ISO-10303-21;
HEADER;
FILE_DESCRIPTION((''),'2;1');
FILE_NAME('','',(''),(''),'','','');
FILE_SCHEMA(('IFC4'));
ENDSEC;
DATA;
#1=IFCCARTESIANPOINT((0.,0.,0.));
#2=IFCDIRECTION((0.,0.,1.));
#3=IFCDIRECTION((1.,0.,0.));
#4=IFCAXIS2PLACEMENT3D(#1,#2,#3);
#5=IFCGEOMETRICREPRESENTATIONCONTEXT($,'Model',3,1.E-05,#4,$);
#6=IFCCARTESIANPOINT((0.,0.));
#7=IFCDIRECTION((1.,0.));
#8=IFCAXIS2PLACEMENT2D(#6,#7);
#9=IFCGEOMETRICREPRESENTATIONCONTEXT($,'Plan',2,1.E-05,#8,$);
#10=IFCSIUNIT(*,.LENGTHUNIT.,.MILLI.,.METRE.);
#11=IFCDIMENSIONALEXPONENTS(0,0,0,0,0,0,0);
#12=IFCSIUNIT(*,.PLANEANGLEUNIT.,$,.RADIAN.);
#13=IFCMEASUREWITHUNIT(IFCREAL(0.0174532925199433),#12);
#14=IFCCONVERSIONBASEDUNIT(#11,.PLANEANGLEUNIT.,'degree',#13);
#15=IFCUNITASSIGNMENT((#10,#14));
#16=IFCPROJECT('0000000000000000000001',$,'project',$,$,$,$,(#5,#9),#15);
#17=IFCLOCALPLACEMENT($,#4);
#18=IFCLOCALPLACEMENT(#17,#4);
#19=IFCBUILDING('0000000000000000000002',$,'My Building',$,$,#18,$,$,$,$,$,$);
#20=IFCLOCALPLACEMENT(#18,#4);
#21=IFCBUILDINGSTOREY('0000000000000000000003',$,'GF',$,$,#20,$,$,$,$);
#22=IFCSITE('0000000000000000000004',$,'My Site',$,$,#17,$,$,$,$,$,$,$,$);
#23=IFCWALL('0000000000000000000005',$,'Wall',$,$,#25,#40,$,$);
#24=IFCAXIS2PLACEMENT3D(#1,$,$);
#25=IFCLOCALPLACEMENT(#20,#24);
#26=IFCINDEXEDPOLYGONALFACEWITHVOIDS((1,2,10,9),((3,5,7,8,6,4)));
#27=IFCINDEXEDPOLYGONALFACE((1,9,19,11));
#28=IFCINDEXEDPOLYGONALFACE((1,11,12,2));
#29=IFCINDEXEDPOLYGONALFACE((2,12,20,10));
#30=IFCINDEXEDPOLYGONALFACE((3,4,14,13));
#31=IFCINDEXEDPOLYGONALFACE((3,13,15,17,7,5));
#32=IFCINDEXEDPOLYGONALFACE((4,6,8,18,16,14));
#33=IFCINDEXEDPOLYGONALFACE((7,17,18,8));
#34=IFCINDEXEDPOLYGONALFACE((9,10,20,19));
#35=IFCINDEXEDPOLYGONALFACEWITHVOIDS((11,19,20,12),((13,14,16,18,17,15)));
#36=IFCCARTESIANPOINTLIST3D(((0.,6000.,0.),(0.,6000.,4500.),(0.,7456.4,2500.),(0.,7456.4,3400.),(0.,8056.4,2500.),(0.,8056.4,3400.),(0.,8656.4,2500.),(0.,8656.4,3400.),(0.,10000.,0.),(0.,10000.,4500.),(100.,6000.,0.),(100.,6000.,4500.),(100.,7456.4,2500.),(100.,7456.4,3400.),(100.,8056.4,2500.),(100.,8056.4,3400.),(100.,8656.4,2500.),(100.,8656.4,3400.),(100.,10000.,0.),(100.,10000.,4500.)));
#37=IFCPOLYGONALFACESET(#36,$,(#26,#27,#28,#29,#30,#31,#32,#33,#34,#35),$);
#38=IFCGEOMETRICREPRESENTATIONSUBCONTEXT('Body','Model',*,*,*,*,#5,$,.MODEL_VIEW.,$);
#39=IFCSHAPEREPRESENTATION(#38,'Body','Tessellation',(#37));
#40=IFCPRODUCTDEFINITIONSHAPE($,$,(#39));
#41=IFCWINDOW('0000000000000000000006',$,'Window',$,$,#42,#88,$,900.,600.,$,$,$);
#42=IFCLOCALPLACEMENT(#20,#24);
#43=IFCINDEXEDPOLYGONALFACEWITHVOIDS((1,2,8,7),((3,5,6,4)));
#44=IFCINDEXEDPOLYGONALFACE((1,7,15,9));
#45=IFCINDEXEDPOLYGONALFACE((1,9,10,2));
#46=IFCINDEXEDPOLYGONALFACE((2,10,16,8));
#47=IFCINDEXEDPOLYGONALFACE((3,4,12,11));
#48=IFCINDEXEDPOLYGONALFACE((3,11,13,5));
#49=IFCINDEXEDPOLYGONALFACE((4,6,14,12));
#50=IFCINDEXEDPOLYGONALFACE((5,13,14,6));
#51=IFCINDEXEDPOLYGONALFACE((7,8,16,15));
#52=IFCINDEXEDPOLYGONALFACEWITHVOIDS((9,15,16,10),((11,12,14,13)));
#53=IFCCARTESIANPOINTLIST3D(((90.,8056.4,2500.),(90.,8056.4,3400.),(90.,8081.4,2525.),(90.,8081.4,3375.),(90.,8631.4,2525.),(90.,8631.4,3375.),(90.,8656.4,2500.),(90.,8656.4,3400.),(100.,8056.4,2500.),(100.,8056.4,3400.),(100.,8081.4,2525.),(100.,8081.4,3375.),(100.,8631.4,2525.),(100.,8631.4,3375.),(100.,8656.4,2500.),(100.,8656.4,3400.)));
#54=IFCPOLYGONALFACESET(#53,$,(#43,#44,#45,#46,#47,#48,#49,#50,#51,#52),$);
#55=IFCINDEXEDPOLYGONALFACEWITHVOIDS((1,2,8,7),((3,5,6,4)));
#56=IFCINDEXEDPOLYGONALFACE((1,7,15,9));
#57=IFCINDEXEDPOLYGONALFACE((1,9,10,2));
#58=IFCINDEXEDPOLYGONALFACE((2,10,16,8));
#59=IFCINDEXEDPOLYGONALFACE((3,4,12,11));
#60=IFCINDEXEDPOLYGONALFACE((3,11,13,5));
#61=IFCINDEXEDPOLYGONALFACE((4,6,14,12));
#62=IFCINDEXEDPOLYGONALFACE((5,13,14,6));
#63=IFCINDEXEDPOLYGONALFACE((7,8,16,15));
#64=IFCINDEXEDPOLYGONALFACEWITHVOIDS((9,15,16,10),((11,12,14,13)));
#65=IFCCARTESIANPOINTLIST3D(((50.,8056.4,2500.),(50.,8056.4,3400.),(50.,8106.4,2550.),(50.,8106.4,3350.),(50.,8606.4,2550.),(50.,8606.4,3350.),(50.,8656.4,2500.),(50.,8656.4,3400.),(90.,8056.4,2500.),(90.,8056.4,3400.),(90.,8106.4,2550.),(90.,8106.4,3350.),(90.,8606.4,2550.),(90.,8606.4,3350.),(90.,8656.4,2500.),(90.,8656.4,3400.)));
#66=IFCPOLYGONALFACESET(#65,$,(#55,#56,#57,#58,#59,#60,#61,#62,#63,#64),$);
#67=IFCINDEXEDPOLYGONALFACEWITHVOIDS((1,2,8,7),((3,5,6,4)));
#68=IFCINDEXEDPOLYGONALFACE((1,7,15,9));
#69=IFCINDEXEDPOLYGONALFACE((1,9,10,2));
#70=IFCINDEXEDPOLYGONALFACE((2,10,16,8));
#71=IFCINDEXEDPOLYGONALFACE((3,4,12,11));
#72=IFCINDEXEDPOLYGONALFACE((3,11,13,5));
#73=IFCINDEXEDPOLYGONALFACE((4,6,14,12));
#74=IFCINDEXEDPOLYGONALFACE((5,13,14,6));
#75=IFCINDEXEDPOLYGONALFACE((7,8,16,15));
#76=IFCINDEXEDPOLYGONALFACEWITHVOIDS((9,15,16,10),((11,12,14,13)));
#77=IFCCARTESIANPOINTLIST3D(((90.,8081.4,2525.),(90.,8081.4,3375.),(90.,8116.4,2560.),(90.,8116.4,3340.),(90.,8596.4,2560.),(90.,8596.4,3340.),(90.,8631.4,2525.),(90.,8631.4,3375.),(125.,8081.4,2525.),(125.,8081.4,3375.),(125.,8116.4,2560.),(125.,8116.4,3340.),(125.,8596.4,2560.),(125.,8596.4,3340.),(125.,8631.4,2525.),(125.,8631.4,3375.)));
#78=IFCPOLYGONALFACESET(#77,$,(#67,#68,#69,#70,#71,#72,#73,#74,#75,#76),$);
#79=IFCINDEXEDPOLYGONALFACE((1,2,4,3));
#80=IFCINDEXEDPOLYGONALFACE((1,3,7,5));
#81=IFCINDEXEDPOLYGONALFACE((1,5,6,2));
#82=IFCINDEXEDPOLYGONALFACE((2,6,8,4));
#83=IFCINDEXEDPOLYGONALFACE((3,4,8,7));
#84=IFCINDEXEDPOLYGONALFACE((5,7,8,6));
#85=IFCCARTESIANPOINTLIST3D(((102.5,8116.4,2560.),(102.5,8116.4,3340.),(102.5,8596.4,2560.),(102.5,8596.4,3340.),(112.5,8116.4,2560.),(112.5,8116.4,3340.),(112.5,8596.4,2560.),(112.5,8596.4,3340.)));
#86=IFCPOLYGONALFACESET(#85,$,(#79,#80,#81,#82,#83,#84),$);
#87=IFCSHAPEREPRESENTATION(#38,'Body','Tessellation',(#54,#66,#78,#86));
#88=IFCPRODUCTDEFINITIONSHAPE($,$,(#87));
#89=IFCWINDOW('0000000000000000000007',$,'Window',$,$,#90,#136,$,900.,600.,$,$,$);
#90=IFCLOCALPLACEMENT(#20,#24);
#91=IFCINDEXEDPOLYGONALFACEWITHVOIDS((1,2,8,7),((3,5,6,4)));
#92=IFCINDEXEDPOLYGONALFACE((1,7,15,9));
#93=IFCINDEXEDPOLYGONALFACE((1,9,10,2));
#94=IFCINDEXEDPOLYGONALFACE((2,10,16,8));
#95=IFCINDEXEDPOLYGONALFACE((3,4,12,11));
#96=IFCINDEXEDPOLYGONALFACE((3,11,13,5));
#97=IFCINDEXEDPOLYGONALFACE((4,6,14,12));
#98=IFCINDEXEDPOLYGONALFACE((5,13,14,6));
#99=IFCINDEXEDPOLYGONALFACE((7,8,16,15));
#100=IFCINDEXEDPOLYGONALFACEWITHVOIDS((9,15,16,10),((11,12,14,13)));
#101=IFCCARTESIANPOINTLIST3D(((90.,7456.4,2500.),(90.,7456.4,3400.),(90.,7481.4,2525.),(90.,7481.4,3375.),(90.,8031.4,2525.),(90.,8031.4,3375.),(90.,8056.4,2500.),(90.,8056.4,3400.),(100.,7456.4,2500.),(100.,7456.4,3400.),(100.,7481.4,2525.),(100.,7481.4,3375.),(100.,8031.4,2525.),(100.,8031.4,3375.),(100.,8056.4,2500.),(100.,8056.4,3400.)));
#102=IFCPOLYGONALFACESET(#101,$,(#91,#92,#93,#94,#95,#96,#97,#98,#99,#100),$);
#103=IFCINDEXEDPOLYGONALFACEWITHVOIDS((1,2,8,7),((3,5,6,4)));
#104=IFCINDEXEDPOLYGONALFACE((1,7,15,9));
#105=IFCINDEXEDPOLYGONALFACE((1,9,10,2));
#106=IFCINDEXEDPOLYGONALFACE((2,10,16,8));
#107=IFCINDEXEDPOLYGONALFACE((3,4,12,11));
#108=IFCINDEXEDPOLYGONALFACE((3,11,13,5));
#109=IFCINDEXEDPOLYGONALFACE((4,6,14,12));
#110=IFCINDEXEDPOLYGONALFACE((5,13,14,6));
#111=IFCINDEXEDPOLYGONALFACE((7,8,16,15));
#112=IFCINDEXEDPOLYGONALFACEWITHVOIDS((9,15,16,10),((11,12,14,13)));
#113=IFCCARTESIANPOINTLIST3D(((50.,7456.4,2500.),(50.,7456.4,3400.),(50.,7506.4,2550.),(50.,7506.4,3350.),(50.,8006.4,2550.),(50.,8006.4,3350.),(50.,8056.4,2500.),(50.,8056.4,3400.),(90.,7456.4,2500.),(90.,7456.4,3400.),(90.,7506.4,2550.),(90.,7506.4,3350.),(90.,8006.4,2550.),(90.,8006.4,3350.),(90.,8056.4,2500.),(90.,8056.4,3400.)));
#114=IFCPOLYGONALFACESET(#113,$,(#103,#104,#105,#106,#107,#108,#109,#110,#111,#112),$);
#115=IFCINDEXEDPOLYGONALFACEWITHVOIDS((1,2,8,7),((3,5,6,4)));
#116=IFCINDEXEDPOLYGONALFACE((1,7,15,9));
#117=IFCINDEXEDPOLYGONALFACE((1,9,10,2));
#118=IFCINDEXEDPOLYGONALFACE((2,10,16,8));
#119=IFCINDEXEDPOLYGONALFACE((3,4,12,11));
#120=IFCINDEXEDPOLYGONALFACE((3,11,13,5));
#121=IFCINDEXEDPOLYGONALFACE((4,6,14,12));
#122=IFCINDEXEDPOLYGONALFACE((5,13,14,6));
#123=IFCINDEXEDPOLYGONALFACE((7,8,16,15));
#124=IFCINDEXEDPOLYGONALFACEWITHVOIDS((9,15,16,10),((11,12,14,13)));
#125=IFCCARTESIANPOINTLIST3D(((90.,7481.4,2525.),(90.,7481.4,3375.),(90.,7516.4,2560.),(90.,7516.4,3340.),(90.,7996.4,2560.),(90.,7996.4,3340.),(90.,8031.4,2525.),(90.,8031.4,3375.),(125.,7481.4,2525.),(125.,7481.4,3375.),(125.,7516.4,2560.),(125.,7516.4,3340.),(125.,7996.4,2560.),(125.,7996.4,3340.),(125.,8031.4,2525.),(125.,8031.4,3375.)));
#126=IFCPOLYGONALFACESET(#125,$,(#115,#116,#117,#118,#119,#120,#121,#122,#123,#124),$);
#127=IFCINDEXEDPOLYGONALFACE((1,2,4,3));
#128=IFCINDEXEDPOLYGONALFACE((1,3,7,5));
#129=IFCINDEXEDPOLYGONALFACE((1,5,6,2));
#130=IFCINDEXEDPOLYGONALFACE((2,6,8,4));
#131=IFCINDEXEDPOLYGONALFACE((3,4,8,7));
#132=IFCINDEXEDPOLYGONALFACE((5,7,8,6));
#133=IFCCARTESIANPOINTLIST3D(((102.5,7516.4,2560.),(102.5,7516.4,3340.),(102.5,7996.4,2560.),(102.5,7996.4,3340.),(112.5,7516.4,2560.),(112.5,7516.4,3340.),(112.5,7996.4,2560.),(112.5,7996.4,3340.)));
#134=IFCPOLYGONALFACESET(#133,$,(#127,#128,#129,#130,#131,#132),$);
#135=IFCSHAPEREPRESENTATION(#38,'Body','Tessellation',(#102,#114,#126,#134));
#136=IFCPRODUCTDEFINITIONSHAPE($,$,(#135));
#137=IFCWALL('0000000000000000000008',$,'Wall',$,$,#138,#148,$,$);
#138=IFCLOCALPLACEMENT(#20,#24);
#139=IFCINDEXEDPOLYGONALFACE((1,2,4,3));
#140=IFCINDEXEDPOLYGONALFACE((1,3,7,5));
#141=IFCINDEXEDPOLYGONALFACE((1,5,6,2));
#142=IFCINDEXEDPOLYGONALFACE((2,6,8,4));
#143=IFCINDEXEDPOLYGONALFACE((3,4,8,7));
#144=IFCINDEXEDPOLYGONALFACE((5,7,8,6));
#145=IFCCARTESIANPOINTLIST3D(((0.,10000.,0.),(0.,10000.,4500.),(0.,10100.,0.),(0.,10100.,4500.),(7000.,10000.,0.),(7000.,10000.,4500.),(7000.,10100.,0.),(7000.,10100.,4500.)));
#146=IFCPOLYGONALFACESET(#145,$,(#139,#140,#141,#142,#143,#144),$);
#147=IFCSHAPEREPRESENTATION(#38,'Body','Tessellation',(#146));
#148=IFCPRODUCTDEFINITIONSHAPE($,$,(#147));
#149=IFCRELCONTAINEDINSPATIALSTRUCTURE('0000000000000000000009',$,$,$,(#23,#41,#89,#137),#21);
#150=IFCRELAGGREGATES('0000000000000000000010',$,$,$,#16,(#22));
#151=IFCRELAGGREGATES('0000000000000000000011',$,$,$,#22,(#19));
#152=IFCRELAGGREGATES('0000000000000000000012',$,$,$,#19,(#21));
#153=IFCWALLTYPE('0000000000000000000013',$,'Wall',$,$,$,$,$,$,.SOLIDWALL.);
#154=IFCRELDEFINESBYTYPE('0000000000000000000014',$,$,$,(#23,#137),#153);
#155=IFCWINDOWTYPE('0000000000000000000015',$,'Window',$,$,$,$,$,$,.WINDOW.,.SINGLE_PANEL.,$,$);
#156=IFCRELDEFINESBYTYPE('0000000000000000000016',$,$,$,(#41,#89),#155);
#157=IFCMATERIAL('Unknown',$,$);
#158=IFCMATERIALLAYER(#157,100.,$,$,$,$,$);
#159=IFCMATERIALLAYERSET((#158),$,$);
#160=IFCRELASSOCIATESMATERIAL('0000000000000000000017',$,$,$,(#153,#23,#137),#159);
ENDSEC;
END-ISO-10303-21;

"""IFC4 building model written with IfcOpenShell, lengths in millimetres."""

from ifc_helpers import new_model, entity, si_unit, converted_unit, frame, origin_with_axes, origin_2d_with_axis, place, context, subcontext, project, spatial, line, indexed_curve, outline, extrude, shape, source, transform, mapped, material, layer, layer_set, layer_usage, type_object, type_shapes, element, fill, save


model = new_model("IFC4")

# Units and contexts
model_context = context("Model", 3, precision=1e-05, world=origin_with_axes())
plan_context = context("Plan", 2, precision=1e-05, world=origin_2d_with_axis())
body_context_1 = subcontext(model_context, "Body", "Model", "MODEL_VIEW")
body_context_2 = subcontext(plan_context, "Body", "Plan", "PLAN_VIEW")
ifc_project = project(units=[si_unit("LENGTHUNIT", "METRE", prefix="MILLI"), converted_unit("PLANEANGLEUNIT", "degree", entity("IfcReal", 0.0174532925199433), si_unit("PLANEANGLEUNIT", "RADIAN"), dimensions=[0, 0, 0, 0, 0, 0, 0])], contexts=[model_context, plan_context])

# Site, building, storey
site_placement = place(None, origin_with_axes())
site = spatial("IfcSite", under=ifc_project, at=site_placement, Name="My Site")
building_placement = place(site_placement, origin_with_axes())
building = spatial("IfcBuilding", under=site, at=building_placement, Name="My Building")
storey_placement = place(building_placement, origin_with_axes())
storey = spatial("IfcBuildingStorey", under=building, at=storey_placement, Name="GF")

# Shared definitions
ifc_material = material(Name="Unknown")

# Wall, openings, windows
ifc_layer_1 = layer(ifc_material, 100.0)
ifc_layer_set_1 = layer_set([ifc_layer_1])
ifc_layer_usage_1 = layer_usage(ifc_layer_set_1, "AXIS2", "POSITIVE", 0.0)
wall_type = type_object("IfcWallType", Name="Wall", PredefinedType="SOLIDWALL", material=ifc_layer_set_1)
wall_1_placement = place(storey_placement, frame((0.0, 10000.0, 0.0), z_axis=(0.0, 0.0, 1.0), x_axis=(0.0, -1.0, 0.0)))
wall_1 = element("IfcWall", 1, at=wall_1_placement, inside=storey, type_object=wall_type, material=ifc_layer_usage_1, Name="Wall", context=body_context_1, shape_type="SweptSolid", body=[
    extrude(outline(indexed_curve([(0.0, 0.0), (0.0, 100.0), (4000.0, 100.0), (4000.0, 0.0)], segments=[line(1, 2, 3, 4, 1)])), origin_with_axes(), (0.0, 0.0, 1.0), 4500.0),
])
shared_shape_1 = source(origin_with_axes(), body_context_1, "Body", "SweptSolid", [
    extrude(outline(indexed_curve([(0.0, 0.0), (600.0, 0.0), (600.0, 900.0), (0.0, 900.0)], segments=[line(1, 2, 3, 4, 1)])), frame((0.0, -600.0, 0.0), z_axis=(0.0, -1.0, 0.0), x_axis=(1.0, 0.0, 0.0)), (0.0, 0.0, -1.0), 1200.0),
])
opening_1_placement = place(wall_1_placement, frame((1343.6, 0.0, 2500.0), z_axis=(0.0, 0.0, 1.0), x_axis=(1.0, 0.0, 0.0)))
opening_1 = element("IfcOpeningElement", 2, at=opening_1_placement, cuts=wall_1, PredefinedType="OPENING", context=body_context_1, shape_type="MappedRepresentation", body=[
    mapped(shared_shape_1, transform((0.0, 0.0, 0.0), x_axis=(1.0, 0.0, 0.0), y_axis=(0.0, 1.0, 0.0), z_axis=(0.0, 0.0, 1.0), scale=1.0)),
])
opening_2_placement = place(wall_1_placement, frame((1943.6, 0.0, 2500.0), z_axis=(0.0, 0.0, 1.0), x_axis=(1.0, 0.0, 0.0)))
opening_2 = element("IfcOpeningElement", 3, at=opening_2_placement, cuts=wall_1, PredefinedType="OPENING", context=body_context_1, shape_type="MappedRepresentation", body=[
    mapped(shared_shape_1, transform((0.0, 0.0, 0.0), x_axis=(1.0, 0.0, 0.0), y_axis=(0.0, 1.0, 0.0), z_axis=(0.0, 0.0, 1.0), scale=1.0)),
])
window_type = type_object("IfcWindowType", Name="Window", PartitioningType="SINGLE_PANEL", PredefinedType="WINDOW")
shared_shape_2 = source(origin_with_axes(), body_context_1, "Body", "SweptSolid", [
    extrude(outline(indexed_curve([(0.0, 0.0), (600.0, 0.0), (600.0, 900.0), (0.0, 900.0)], segments=[line(1, 2, 3, 4, 1)]), holes=[indexed_curve([(25.0, 25.0), (575.0, 25.0), (575.0, 875.0), (25.0, 875.0)], segments=[line(1, 2, 3, 4, 1)])]), frame((0.0, 90.0, 0.0), z_axis=(0.0, -1.0, 0.0), x_axis=(1.0, 0.0, 0.0)), (0.0, 0.0, -1.0), 10.0),
    extrude(outline(indexed_curve([(0.0, 0.0), (600.0, 0.0), (600.0, 900.0), (0.0, 900.0)], segments=[line(1, 2, 3, 4, 1)]), holes=[indexed_curve([(50.0, 50.0), (550.0, 50.0), (550.0, 850.0), (50.0, 850.0)], segments=[line(1, 2, 3, 4, 1)])]), frame((0.0, 50.0, 0.0), z_axis=(0.0, -1.0, 0.0), x_axis=(1.0, 0.0, 0.0)), (0.0, 0.0, -1.0), 40.0),
    extrude(outline(indexed_curve([(0.0, 0.0), (550.0, 0.0), (550.0, 850.0), (0.0, 850.0)], segments=[line(1, 2, 3, 4, 1)]), holes=[indexed_curve([(35.0, 35.0), (515.0, 35.0), (515.0, 815.0), (35.0, 815.0)], segments=[line(1, 2, 3, 4, 1)])]), frame((25.0, 90.0, 25.0), z_axis=(0.0, -1.0, 0.0), x_axis=(1.0, 0.0, 0.0)), (0.0, 0.0, -1.0), 35.0),
    extrude(outline(indexed_curve([(35.0, 35.0), (515.0, 35.0), (515.0, 815.0), (35.0, 815.0)], segments=[line(1, 2, 3, 4, 1)])), frame((25.0, 102.5, 25.0), z_axis=(0.0, -1.0, 0.0), x_axis=(1.0, 0.0, 0.0)), (0.0, 0.0, -1.0), 10.0),
])
shared_shape_3 = source(origin_with_axes(), body_context_2, "Body", "Curve2D", [
    entity("IfcIndexedPolyCurve", entity("IfcCartesianPointList2D", [[50.0, 50.0], [550.0, 50.0]])),
    entity("IfcIndexedPolyCurve", entity("IfcCartesianPointList2D", [[0.0, 100.0], [25.0, 100.0], [25.0, 90.0], [50.0, 90.0], [50.0, 50.0], [0.0, 50.0]]), [entity("IfcLineIndex", [1, 2, 3, 4, 5, 6, 1])]),
    entity("IfcIndexedPolyCurve", entity("IfcCartesianPointList2D", [[600.0, 100.0], [575.0, 100.0], [575.0, 90.0], [550.0, 90.0], [550.0, 50.0], [600.0, 50.0]]), [entity("IfcLineIndex", [1, 2, 3, 4, 5, 6, 1])]),
    entity("IfcIndexedPolyCurve", entity("IfcCartesianPointList2D", [[25.0, 90.0], [60.0, 90.0], [60.0, 125.0], [25.0, 125.0]]), [entity("IfcLineIndex", [1, 2, 3, 4, 1])]),
    entity("IfcIndexedPolyCurve", entity("IfcCartesianPointList2D", [[575.0, 90.0], [540.0, 90.0], [540.0, 125.0], [575.0, 125.0]]), [entity("IfcLineIndex", [1, 2, 3, 4, 1])]),
    entity("IfcIndexedPolyCurve", entity("IfcCartesianPointList2D", [[60.0, 90.0], [540.0, 90.0]])),
    entity("IfcIndexedPolyCurve", entity("IfcCartesianPointList2D", [[60.0, 125.0], [540.0, 125.0]])),
    entity("IfcIndexedPolyCurve", entity("IfcCartesianPointList2D", [[60.0, 107.5], [540.0, 107.5]])),
])
type_shapes(window_type, [shared_shape_2, shared_shape_3])
window_1_placement = place(opening_1_placement, frame((0.0, 0.0, 0.0), z_axis=(0.0, 0.0, 1.0), x_axis=(1.0, 0.0, 0.0)))
window_1 = element("IfcWindow", 4, at=window_1_placement, inside=storey, type_object=window_type, Name="Window", OverallHeight=900.0, OverallWidth=600.0, shapes=[
    shape(body_context_1, "Body", "MappedRepresentation", [mapped(shared_shape_2, transform((0.0, 0.0, 0.0), x_axis=(1.0, 0.0, 0.0), y_axis=(0.0, 1.0, 0.0), z_axis=(0.0, 0.0, 1.0), scale=1.0))]),
    shape(body_context_2, "Body", "MappedRepresentation", [mapped(shared_shape_3, transform((0.0, 0.0, 0.0), x_axis=(1.0, 0.0, 0.0), y_axis=(0.0, 1.0, 0.0), z_axis=(0.0, 0.0, 1.0), scale=1.0))]),
])
fill(opening_1, window_1)
window_2_placement = place(opening_2_placement, frame((0.0, 0.0, 0.0), z_axis=(0.0, 0.0, 1.0), x_axis=(1.0, 0.0, 0.0)))
window_2 = element("IfcWindow", 5, at=window_2_placement, inside=storey, type_object=window_type, Name="Window", OverallHeight=900.0, OverallWidth=600.0, shapes=[
    shape(body_context_1, "Body", "MappedRepresentation", [mapped(shared_shape_2, transform((0.0, 0.0, 0.0), x_axis=(1.0, 0.0, 0.0), y_axis=(0.0, 1.0, 0.0), z_axis=(0.0, 0.0, 1.0), scale=1.0))]),
    shape(body_context_2, "Body", "MappedRepresentation", [mapped(shared_shape_3, transform((0.0, 0.0, 0.0), x_axis=(1.0, 0.0, 0.0), y_axis=(0.0, 1.0, 0.0), z_axis=(0.0, 0.0, 1.0), scale=1.0))]),
])
fill(opening_2, window_2)

# Wall
ifc_layer_usage_2 = layer_usage(ifc_layer_set_1, "AXIS2", "POSITIVE", 0.0)
wall_2_placement = place(storey_placement, frame((0.0, 10000.0, 0.0), z_axis=(0.0, 0.0, 1.0), x_axis=(1.0, 0.0, 0.0)))
element("IfcWall", 6, at=wall_2_placement, inside=storey, type_object=wall_type, material=ifc_layer_usage_2, Name="Wall", context=body_context_1, shape_type="SweptSolid", body=[
    extrude(outline(indexed_curve([(0.0, 0.0), (0.0, 100.0), (7000.0, 100.0), (7000.0, 0.0)], segments=[line(1, 2, 3, 4, 1)])), origin_with_axes(), (0.0, 0.0, 1.0), 4500.0),
])

save(model, "model.ifc")
